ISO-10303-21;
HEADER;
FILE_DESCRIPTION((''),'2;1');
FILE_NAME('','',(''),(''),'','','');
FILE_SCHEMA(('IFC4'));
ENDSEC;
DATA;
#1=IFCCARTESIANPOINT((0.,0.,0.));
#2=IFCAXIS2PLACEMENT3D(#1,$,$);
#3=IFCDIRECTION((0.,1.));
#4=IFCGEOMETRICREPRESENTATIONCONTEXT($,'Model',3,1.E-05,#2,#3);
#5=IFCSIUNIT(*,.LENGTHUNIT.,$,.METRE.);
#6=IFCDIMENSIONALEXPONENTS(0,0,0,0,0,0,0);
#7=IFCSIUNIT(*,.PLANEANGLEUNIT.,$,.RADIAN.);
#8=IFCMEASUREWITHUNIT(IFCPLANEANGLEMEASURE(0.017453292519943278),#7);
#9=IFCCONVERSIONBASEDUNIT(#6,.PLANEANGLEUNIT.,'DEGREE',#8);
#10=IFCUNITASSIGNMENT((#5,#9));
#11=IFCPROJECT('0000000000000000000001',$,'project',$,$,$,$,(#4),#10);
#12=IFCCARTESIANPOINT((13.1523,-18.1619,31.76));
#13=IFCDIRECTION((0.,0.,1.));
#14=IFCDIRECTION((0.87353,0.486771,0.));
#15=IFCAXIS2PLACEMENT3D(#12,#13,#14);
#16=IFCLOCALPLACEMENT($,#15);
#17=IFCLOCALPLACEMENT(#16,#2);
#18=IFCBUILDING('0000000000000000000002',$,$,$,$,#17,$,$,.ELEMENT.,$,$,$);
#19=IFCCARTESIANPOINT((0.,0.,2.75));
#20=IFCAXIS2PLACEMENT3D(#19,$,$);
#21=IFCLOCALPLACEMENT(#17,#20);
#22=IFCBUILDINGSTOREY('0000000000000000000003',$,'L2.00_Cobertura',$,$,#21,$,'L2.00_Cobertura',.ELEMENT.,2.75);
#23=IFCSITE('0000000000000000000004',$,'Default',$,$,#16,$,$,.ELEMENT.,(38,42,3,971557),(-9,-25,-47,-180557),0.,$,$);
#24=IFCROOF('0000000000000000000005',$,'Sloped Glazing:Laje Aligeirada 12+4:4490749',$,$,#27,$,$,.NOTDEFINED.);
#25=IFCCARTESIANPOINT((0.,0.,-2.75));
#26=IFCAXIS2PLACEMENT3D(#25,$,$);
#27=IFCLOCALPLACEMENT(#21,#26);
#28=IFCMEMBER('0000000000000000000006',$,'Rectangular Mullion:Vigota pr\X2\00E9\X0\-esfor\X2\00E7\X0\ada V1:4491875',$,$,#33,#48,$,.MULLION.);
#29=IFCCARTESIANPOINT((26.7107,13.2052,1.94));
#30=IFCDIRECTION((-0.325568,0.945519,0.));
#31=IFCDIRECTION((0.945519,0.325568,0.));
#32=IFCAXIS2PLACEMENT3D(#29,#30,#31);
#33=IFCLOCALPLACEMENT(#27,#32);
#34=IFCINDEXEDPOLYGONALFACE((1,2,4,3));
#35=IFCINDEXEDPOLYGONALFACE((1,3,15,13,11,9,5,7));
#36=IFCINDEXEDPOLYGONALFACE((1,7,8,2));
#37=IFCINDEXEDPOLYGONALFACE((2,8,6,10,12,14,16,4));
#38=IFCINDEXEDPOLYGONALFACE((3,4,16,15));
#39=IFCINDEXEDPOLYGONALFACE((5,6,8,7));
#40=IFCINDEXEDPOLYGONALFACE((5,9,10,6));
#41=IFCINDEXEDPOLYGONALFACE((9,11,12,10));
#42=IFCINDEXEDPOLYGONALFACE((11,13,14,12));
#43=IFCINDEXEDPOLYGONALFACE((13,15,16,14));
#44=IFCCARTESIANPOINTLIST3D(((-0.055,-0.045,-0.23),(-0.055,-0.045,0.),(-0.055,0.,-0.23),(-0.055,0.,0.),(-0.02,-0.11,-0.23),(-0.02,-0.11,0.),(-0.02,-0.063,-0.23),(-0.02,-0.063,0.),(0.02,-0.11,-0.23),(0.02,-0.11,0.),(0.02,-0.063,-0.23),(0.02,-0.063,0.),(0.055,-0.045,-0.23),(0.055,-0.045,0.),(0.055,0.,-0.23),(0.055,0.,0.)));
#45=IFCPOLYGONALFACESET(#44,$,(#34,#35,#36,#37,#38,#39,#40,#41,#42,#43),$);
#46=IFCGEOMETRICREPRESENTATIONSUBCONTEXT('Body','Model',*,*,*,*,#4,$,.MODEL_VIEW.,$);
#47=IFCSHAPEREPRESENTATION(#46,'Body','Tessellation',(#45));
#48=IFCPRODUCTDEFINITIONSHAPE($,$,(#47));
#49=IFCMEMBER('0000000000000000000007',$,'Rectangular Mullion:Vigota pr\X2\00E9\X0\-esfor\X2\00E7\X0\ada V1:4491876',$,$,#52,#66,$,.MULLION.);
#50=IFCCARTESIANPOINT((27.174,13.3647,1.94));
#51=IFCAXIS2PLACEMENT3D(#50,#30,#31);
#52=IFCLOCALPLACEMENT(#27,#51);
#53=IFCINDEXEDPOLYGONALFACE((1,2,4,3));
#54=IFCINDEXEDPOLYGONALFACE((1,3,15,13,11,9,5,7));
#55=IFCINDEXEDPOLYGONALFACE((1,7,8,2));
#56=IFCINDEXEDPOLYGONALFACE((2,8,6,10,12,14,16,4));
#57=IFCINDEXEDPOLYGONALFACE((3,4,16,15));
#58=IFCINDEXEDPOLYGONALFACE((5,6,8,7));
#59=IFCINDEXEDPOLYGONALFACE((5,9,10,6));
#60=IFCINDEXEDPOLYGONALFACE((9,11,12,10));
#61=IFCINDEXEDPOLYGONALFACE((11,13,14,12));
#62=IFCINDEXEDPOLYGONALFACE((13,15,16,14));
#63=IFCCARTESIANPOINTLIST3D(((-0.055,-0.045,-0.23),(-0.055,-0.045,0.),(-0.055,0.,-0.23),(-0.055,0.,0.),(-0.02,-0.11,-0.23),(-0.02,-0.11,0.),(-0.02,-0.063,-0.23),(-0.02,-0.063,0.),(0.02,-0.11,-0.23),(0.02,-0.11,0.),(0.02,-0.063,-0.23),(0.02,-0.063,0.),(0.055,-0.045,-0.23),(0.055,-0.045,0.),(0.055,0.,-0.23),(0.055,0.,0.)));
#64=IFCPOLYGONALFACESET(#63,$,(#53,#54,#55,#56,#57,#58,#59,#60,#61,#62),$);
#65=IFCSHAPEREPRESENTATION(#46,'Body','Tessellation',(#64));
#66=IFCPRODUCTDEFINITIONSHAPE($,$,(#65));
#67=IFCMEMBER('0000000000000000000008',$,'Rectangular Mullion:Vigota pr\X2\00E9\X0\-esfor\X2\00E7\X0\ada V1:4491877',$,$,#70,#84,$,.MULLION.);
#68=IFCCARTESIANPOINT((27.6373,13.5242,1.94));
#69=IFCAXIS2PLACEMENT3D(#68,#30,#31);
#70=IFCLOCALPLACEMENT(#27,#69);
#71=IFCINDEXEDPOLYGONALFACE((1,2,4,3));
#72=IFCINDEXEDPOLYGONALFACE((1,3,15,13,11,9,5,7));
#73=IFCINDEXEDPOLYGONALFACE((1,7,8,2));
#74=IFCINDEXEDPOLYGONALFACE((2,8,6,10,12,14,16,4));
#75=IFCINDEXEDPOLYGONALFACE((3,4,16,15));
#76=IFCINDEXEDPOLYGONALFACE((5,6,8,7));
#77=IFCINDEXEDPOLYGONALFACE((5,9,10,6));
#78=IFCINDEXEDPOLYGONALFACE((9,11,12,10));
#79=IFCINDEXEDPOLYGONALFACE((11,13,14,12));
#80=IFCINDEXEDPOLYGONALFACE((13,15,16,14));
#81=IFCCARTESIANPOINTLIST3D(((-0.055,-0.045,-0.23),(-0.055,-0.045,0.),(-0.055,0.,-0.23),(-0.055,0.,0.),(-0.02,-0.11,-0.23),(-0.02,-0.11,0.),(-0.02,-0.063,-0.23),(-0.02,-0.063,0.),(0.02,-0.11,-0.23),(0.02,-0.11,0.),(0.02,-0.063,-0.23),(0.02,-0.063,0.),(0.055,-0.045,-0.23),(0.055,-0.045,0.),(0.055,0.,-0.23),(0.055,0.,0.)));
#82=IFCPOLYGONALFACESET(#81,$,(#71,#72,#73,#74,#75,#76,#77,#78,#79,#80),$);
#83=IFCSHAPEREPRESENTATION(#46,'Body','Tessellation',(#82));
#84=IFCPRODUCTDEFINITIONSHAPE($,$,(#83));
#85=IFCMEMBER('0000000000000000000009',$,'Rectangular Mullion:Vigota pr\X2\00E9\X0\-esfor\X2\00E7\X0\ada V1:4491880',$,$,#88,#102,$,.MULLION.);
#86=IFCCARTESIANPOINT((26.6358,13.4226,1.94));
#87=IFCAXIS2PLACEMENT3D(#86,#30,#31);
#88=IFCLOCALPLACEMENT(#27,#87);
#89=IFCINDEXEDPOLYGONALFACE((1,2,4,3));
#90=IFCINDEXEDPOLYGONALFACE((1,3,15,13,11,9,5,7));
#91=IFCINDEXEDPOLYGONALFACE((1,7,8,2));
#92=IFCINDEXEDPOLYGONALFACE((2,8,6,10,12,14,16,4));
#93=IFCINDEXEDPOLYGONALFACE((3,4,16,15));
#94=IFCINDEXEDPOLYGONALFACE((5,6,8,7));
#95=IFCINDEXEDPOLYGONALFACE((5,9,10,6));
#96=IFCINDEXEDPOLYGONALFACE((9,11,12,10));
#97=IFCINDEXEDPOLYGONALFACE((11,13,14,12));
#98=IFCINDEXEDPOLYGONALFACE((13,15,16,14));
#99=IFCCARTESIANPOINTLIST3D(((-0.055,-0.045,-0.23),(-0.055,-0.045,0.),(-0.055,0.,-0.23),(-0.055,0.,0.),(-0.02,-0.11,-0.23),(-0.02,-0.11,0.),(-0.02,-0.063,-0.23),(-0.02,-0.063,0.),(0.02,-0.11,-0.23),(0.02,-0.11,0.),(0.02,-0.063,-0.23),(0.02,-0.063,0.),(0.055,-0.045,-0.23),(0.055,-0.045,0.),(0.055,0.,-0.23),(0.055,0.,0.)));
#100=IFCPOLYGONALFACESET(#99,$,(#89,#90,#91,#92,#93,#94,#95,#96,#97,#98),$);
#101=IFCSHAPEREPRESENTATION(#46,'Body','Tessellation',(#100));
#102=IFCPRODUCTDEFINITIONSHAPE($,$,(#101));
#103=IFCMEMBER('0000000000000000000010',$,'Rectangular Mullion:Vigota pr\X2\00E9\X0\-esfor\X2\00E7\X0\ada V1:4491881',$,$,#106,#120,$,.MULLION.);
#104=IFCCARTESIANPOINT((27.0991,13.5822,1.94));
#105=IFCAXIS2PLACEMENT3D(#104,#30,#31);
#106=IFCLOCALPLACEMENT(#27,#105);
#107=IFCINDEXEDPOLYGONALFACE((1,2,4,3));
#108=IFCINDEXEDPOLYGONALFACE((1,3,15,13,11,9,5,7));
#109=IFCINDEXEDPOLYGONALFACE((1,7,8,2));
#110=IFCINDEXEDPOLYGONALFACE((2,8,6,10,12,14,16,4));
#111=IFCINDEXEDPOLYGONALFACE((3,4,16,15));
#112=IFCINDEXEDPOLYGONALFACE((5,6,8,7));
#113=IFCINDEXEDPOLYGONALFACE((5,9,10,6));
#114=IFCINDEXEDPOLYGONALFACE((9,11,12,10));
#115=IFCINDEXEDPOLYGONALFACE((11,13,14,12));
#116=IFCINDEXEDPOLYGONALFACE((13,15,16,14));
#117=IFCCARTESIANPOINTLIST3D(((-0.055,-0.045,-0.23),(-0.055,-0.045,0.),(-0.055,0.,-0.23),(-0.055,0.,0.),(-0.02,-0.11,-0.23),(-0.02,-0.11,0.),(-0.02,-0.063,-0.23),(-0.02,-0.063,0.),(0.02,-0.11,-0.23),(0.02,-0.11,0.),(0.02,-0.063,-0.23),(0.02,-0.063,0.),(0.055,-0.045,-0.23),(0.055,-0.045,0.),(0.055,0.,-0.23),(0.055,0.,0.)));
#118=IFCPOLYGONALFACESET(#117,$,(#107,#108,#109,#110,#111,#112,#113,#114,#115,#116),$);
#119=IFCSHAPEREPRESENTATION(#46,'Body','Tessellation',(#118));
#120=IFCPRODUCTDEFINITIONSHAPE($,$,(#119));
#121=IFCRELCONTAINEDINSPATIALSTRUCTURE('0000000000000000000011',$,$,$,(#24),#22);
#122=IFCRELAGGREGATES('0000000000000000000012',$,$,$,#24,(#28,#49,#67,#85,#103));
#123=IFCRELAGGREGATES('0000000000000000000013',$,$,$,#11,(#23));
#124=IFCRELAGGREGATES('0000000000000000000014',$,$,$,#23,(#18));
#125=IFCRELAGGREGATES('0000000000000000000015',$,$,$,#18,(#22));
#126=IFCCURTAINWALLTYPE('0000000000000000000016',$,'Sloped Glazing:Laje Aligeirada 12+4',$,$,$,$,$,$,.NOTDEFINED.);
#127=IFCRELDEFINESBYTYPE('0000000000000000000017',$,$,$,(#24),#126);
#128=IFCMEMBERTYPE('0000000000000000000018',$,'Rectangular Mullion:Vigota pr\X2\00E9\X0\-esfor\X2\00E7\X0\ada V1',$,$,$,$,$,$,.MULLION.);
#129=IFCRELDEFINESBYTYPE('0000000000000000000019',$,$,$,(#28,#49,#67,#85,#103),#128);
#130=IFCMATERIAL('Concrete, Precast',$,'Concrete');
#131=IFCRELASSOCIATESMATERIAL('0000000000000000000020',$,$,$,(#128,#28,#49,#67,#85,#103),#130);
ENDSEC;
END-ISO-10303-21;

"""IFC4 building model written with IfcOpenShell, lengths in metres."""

from ifc_helpers import new_model, entity, si_unit, converted_unit, direction, frame, origin, place, context, subcontext, project, spatial, indexed_curve, outline, extrude, source, transform, mapped, material, type_object, type_shapes, element, aggregate, save


model = new_model("IFC4")

# Units and contexts
model_context = context("Model", 3, precision=1e-05, world=origin(), true_north=direction((0.0, 1.0)))
body_context = subcontext(model_context, "Body", "Model", "MODEL_VIEW")
ifc_project = project(units=[si_unit("LENGTHUNIT", "METRE"), converted_unit("PLANEANGLEUNIT", "DEGREE", entity("IfcPlaneAngleMeasure", 0.017453292519943278), si_unit("PLANEANGLEUNIT", "RADIAN"), dimensions=[0, 0, 0, 0, 0, 0, 0])], contexts=[model_context])

# Site, building, storey
site_placement = place(None, frame((13.1523, -18.1619, 31.76), z_axis=(0.0, 0.0, 1.0), x_axis=(0.87353, 0.486771, 0.0)))
site = spatial("IfcSite", under=ifc_project, at=site_placement, Name="Default", CompositionType="ELEMENT", RefLatitude=(38, 42, 3, 971557), RefLongitude=(-9, -25, -47, -180557), RefElevation=0.0)
building_placement = place(site_placement, origin())
building = spatial("IfcBuilding", under=site, at=building_placement, CompositionType="ELEMENT")
storey_placement = place(building_placement, frame((0.0, 0.0, 2.75)))
storey = spatial("IfcBuildingStorey", under=building, at=storey_placement, Name="L2.00_Cobertura", LongName="L2.00_Cobertura", CompositionType="ELEMENT", Elevation=2.75)

# Roof, members
curtain_wall_type = type_object("IfcCurtainWallType", Name="Sloped Glazing:Laje Aligeirada 12+4", PredefinedType="NOTDEFINED")
roof_placement = place(storey_placement, frame((0.0, 0.0, -2.75)))
roof = element("IfcRoof", 1, at=roof_placement, inside=storey, type_object=curtain_wall_type, Name="Sloped Glazing:Laje Aligeirada 12+4:4490749", PredefinedType="NOTDEFINED")
ifc_material_1 = material(Name="Concrete, Precast", Category="Concrete")
member_type = type_object("IfcMemberType", Name="Rectangular Mullion:Vigota pré-esforçada V1", PredefinedType="MULLION", material=ifc_material_1)
shared_shape_1 = source(origin(), body_context, "Body", "SweptSolid", [
    extrude(outline(indexed_curve([(-0.055, -0.0545), (0.055, -0.0545), (0.055, -0.0095), (0.02, 0.0085), (0.02, 0.0555), (-0.02, 0.0555), (-0.02, 0.0085), (-0.055, -0.0095), (-0.055, -0.0545)], self_intersect=False)), frame((0.0, -0.0545, -0.23), z_axis=(0.0, 0.0, 1.0), x_axis=(-1.0, 0.0, 0.0)), (0.0, 0.0, 1.0), 0.23),
])
type_shapes(member_type, [shared_shape_1])
member_1_placement = place(roof_placement, frame((26.7107, 13.2052, 1.94), z_axis=(-0.325568, 0.945519, 0.0), x_axis=(0.945519, 0.325568, 0.0)))
member_1 = element("IfcMember", 2, at=member_1_placement, type_object=member_type, material=ifc_material_1, Name="Rectangular Mullion:Vigota pré-esforçada V1:4491875", PredefinedType="MULLION", context=body_context, shape_type="MappedRepresentation", body=[
    mapped(shared_shape_1, transform((0.0, 0.0, 0.0), scale=1.0)),
])
member_2_placement = place(roof_placement, frame((27.174, 13.3647, 1.94), z_axis=(-0.325568, 0.945519, 0.0), x_axis=(0.945519, 0.325568, 0.0)))
member_2 = element("IfcMember", 3, at=member_2_placement, type_object=member_type, material=ifc_material_1, Name="Rectangular Mullion:Vigota pré-esforçada V1:4491876", PredefinedType="MULLION", context=body_context, shape_type="MappedRepresentation", body=[
    mapped(shared_shape_1, transform((0.0, 0.0, 0.0), scale=1.0)),
])
member_3_placement = place(roof_placement, frame((27.6373, 13.5242, 1.94), z_axis=(-0.325568, 0.945519, 0.0), x_axis=(0.945519, 0.325568, 0.0)))
member_3 = element("IfcMember", 4, at=member_3_placement, type_object=member_type, material=ifc_material_1, Name="Rectangular Mullion:Vigota pré-esforçada V1:4491877", PredefinedType="MULLION", context=body_context, shape_type="MappedRepresentation", body=[
    mapped(shared_shape_1, transform((0.0, 0.0, 0.0), scale=1.0)),
])
member_4_placement = place(roof_placement, frame((26.6358, 13.4226, 1.94), z_axis=(-0.325568, 0.945519, 0.0), x_axis=(0.945519, 0.325568, 0.0)))
member_4 = element("IfcMember", 5, at=member_4_placement, type_object=member_type, material=ifc_material_1, Name="Rectangular Mullion:Vigota pré-esforçada V1:4491880", PredefinedType="MULLION", context=body_context, shape_type="MappedRepresentation", body=[
    mapped(shared_shape_1, transform((0.0, 0.0, 0.0), scale=1.0)),
])
member_5_placement = place(roof_placement, frame((27.0991, 13.5822, 1.94), z_axis=(-0.325568, 0.945519, 0.0), x_axis=(0.945519, 0.325568, 0.0)))
member_5 = element("IfcMember", 6, at=member_5_placement, type_object=member_type, material=ifc_material_1, Name="Rectangular Mullion:Vigota pré-esforçada V1:4491881", PredefinedType="MULLION", context=body_context, shape_type="MappedRepresentation", body=[
    mapped(shared_shape_1, transform((0.0, 0.0, 0.0), scale=1.0)),
])
aggregate(roof, [member_1, member_2, member_3, member_4, member_5])

save(model, "model.ifc")
